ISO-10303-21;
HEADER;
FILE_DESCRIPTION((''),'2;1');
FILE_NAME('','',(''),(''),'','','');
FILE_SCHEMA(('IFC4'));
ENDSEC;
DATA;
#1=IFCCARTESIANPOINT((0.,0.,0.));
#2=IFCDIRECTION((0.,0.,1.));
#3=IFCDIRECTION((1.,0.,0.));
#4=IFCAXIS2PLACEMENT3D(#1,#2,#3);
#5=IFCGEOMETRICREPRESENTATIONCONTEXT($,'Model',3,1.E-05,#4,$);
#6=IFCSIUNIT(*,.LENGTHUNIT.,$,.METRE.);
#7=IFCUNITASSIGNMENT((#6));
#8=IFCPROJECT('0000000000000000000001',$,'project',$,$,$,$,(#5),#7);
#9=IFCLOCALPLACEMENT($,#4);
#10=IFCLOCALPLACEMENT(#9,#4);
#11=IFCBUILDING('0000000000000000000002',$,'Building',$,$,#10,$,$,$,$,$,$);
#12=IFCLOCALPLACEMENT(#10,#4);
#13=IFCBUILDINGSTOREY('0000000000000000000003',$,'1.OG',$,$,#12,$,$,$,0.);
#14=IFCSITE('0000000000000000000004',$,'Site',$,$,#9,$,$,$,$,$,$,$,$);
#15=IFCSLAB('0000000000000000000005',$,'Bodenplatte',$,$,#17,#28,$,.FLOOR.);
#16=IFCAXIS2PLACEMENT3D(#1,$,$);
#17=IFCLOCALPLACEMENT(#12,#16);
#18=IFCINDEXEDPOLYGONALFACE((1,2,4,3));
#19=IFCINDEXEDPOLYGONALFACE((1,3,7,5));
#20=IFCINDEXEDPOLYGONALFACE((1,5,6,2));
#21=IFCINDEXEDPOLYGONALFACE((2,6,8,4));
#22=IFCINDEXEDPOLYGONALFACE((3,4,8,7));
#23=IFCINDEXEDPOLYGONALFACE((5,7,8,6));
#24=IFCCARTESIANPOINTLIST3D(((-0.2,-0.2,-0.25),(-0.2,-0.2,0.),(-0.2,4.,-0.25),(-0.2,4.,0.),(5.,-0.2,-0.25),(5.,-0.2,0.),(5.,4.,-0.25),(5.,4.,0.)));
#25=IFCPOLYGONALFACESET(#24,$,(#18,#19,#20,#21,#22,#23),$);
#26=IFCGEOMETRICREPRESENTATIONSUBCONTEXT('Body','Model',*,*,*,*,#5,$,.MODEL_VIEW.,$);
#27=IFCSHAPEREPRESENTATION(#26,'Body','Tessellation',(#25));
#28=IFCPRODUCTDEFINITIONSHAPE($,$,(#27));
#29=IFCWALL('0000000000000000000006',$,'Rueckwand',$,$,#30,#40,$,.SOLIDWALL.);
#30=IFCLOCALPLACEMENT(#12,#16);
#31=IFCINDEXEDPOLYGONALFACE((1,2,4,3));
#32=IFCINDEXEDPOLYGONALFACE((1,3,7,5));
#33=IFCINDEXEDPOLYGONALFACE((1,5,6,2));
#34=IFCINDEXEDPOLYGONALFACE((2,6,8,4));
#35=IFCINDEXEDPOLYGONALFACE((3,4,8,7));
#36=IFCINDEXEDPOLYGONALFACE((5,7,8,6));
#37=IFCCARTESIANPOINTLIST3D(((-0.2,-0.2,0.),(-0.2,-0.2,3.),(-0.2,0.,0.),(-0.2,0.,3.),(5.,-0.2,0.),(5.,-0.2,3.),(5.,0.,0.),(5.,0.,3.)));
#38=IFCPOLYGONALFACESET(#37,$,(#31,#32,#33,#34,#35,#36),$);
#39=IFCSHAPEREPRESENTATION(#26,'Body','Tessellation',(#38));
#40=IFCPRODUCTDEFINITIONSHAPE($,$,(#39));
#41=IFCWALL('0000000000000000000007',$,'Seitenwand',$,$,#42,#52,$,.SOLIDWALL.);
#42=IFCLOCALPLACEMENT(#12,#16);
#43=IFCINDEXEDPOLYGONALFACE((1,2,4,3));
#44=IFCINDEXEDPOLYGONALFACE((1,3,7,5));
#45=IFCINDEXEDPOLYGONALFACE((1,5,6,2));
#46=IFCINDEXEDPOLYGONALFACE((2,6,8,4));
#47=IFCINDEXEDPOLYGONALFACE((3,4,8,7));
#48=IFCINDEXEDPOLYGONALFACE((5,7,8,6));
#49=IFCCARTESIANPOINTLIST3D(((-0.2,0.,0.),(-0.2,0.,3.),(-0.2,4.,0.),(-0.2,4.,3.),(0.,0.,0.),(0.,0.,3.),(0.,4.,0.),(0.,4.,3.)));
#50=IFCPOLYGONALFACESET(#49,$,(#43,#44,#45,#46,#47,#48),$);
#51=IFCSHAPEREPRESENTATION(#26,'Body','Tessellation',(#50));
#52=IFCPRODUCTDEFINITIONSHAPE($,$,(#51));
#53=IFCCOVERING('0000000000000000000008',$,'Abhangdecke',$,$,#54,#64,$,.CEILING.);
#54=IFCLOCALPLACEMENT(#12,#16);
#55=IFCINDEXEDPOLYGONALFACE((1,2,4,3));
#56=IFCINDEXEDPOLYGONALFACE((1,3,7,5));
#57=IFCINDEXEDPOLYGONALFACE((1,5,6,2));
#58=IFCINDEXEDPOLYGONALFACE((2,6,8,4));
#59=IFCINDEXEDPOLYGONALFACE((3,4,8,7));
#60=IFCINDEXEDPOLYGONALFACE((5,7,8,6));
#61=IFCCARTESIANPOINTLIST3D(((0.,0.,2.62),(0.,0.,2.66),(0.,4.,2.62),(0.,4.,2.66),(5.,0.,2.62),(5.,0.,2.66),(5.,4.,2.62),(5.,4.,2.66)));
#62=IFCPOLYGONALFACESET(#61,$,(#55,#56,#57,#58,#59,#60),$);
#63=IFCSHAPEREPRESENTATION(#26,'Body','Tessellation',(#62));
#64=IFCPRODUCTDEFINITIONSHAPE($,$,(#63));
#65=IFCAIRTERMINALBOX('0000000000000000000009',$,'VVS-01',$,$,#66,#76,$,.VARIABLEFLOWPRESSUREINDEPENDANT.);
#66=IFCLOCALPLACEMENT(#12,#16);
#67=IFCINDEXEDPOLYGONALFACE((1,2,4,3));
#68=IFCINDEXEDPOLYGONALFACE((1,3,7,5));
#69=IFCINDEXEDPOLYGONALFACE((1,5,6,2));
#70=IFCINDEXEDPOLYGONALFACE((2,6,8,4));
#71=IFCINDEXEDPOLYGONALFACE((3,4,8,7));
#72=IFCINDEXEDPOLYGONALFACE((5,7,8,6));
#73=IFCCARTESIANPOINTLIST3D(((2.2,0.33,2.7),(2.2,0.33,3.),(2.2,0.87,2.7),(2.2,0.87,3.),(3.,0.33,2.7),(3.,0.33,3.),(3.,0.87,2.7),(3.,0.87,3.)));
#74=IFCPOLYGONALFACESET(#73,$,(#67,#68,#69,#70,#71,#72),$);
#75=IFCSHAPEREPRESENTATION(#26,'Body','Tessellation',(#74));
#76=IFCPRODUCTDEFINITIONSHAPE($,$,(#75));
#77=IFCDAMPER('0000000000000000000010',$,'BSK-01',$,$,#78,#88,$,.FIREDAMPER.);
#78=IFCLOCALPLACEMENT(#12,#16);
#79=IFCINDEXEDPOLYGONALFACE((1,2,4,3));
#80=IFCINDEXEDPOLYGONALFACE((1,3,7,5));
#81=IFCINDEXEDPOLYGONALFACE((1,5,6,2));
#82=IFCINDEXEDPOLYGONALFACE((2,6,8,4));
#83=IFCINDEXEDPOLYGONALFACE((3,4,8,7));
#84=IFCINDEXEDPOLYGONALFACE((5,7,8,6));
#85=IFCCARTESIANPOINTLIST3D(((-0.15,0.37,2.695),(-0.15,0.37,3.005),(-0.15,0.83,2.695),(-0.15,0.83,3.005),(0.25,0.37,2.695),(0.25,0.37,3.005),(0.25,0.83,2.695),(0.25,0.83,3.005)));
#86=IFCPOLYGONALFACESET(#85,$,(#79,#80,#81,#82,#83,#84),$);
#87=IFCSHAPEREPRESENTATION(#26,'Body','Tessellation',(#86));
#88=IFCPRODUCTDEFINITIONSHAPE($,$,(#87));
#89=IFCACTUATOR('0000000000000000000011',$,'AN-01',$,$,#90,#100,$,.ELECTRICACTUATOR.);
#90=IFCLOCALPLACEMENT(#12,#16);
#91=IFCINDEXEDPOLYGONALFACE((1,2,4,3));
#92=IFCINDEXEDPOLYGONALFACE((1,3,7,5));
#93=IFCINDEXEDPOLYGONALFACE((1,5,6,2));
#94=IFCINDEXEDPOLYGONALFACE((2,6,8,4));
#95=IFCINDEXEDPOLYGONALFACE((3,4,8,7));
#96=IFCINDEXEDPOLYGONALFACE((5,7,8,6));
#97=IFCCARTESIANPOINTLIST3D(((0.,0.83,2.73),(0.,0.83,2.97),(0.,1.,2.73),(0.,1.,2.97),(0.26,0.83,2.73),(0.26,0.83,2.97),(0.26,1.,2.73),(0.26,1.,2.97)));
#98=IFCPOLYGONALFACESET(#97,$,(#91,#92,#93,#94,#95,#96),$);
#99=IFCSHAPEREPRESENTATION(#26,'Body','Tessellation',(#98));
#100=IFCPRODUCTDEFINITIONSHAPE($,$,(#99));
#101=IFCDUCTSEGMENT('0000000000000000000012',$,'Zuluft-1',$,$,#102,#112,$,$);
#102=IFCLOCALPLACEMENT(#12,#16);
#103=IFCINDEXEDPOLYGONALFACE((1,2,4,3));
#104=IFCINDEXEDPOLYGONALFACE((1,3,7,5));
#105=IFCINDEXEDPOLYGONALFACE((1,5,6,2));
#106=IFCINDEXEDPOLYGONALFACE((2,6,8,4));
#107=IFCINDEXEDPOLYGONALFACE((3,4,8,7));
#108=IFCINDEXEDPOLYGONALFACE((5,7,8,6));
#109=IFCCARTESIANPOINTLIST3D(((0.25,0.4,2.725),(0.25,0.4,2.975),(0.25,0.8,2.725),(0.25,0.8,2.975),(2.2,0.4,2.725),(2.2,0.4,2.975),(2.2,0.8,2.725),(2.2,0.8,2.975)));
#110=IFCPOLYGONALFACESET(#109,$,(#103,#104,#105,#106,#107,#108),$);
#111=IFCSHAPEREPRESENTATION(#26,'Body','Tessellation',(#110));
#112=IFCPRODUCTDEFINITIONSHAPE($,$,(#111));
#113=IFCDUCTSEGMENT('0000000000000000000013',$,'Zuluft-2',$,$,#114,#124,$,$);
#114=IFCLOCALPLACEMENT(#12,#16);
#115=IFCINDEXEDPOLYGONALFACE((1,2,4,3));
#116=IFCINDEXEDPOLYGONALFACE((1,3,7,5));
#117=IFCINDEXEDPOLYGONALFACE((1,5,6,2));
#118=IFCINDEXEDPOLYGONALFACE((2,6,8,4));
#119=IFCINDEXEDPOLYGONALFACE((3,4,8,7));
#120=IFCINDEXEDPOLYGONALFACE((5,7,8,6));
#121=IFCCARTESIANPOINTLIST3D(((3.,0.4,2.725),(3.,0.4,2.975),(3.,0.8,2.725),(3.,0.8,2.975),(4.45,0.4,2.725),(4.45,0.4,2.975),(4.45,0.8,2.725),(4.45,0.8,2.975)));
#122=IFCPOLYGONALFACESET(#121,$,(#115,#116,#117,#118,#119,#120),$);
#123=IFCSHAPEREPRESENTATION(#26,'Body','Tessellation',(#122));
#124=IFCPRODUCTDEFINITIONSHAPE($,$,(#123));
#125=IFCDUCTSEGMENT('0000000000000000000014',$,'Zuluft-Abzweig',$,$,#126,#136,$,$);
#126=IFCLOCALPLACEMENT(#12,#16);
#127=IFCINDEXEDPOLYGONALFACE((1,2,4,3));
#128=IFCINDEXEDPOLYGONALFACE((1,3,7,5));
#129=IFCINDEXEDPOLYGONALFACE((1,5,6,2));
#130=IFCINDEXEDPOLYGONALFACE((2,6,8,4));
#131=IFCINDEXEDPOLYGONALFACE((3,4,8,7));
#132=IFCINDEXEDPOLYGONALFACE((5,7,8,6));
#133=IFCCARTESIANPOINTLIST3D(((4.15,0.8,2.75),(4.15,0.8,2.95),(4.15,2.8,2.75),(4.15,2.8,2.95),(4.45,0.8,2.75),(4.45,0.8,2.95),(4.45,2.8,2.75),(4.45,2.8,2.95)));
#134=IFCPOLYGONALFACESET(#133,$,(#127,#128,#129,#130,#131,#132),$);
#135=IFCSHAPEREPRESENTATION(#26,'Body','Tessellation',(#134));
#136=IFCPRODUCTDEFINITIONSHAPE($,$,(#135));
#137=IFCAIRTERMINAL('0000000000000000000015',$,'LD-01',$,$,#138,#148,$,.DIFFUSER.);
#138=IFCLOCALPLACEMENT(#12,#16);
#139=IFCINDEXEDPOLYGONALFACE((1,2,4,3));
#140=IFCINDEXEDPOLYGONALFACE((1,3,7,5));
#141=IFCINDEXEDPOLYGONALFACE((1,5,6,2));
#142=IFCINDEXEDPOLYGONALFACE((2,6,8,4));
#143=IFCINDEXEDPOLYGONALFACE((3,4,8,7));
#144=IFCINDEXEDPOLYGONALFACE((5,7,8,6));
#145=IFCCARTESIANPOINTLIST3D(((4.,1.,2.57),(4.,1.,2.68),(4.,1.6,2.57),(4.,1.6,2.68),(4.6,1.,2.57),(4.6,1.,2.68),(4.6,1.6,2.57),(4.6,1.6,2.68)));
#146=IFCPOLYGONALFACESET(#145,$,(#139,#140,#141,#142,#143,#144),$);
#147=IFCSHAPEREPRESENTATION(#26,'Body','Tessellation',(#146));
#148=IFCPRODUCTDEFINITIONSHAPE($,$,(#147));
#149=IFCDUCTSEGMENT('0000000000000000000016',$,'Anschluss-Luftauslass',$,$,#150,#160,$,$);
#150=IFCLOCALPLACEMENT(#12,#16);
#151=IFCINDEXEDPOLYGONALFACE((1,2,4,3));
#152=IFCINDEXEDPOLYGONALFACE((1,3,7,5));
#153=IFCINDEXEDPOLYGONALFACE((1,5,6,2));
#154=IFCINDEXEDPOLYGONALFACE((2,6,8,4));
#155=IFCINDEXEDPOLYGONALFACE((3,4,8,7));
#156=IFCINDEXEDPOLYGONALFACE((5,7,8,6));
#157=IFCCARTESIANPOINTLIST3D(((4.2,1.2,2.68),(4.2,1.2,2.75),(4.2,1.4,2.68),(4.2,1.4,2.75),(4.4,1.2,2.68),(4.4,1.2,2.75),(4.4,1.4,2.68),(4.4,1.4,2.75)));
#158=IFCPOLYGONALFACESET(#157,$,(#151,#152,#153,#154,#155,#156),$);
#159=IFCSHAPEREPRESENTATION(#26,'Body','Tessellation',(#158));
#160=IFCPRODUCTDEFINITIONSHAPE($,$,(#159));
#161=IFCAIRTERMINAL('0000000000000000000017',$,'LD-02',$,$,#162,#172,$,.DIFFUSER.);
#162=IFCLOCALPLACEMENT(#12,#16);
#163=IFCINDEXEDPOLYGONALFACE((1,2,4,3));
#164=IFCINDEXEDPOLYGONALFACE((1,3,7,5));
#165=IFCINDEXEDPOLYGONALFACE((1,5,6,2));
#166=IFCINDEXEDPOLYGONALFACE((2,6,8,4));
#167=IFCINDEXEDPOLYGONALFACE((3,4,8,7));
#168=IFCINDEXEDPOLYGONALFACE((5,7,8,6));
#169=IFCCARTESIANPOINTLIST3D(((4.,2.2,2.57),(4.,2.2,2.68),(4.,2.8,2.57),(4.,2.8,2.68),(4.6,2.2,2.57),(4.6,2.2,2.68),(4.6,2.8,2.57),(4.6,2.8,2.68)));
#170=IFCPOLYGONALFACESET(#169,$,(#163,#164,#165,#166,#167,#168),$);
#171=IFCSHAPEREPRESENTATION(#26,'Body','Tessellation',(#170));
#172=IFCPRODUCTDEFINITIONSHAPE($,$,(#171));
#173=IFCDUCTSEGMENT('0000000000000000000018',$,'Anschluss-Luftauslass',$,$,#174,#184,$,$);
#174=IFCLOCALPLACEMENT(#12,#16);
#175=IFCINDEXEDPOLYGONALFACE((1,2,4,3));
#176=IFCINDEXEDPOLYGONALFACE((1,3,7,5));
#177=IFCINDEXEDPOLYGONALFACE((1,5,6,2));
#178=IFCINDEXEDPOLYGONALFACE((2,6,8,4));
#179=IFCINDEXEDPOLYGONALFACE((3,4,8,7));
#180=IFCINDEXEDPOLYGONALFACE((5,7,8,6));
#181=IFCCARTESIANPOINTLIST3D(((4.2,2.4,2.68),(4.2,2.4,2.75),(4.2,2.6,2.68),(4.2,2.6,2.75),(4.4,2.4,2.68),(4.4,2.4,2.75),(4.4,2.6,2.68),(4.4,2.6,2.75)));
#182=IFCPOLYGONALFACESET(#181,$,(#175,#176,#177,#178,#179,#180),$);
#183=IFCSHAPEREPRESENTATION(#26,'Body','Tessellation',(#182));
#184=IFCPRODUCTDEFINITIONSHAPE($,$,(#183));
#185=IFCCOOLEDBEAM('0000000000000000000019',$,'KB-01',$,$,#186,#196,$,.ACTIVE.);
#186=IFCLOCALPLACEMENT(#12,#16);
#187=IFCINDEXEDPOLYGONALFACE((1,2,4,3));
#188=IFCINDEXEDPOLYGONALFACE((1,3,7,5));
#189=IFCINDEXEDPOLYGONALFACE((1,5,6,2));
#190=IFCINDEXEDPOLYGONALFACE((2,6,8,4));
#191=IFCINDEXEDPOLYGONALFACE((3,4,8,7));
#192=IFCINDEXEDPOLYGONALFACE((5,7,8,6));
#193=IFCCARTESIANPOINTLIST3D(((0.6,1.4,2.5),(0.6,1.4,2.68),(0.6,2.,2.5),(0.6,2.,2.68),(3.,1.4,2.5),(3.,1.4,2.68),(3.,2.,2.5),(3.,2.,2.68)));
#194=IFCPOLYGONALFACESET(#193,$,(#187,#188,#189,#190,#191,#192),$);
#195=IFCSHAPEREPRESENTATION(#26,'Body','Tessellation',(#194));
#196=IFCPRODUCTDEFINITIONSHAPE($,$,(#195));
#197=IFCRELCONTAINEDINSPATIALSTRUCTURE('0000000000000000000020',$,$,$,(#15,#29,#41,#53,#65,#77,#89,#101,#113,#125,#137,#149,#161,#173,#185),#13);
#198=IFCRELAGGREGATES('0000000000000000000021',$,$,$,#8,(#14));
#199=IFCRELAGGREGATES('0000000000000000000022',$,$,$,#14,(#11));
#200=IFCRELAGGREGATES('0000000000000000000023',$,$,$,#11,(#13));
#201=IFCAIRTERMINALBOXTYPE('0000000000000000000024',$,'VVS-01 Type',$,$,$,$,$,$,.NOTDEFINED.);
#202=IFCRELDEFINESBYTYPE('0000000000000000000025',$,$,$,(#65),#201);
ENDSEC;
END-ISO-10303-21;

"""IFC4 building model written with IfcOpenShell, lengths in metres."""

from ifc_helpers import new_model, si_unit, frame, origin_with_axes, place, context, subcontext, project, spatial, polyline, outline, extrude, type_object, element, save


model = new_model("IFC4")

# Units and contexts
model_context = context("Model", 3, precision=1e-05, world=origin_with_axes())
body_context = subcontext(model_context, "Body", "Model", "MODEL_VIEW")
ifc_project = project(units=[si_unit("LENGTHUNIT", "METRE")], contexts=[model_context])

# Site, building, storey
site_placement = place(None, origin_with_axes())
site = spatial("IfcSite", under=ifc_project, at=site_placement, Name="Site")
building_placement = place(site_placement, origin_with_axes())
building = spatial("IfcBuilding", under=site, at=building_placement, Name="Building")
storey_placement = place(building_placement, origin_with_axes())
storey = spatial("IfcBuildingStorey", under=building, at=storey_placement, Name="1.OG", Elevation=0.0)

# Slab
slab_placement = place(storey_placement, frame((0.0, 0.0, -0.25), z_axis=(0.0, 0.0, 1.0), x_axis=(1.0, 0.0, 0.0)))
element("IfcSlab", 1, at=slab_placement, inside=storey, Name="Bodenplatte", PredefinedType="FLOOR", context=body_context, shape_type="SweptSolid", body=[
    extrude(outline(polyline([(-0.2, -0.2, 0.0), (5.0, -0.2, 0.0), (5.0, 4.0, 0.0), (-0.2, 4.0, 0.0), (-0.2, -0.2, 0.0)])), origin_with_axes(), (0.0, 0.0, 1.0), 0.25),
])

# Walls
wall_1_placement = place(storey_placement, frame((-0.2, -0.2, 0.0), z_axis=(0.0, 0.0, 1.0), x_axis=(1.0, 0.0, 0.0)))
element("IfcWall", 2, at=wall_1_placement, inside=storey, Name="Rueckwand", PredefinedType="SOLIDWALL", context=body_context, shape_type="SweptSolid", body=[
    extrude(outline(polyline([(0.0, 0.0, 0.0), (5.2, 0.0, 0.0), (5.2, 0.2, 0.0), (0.0, 0.2, 0.0), (0.0, 0.0, 0.0)])), origin_with_axes(), (0.0, 0.0, 1.0), 3.0),
])
wall_2_placement = place(storey_placement, frame((0.0, 0.0, 0.0), z_axis=(0.0, 0.0, 1.0), x_axis=(0.0, 1.0, 0.0)))
element("IfcWall", 3, at=wall_2_placement, inside=storey, Name="Seitenwand", PredefinedType="SOLIDWALL", context=body_context, shape_type="SweptSolid", body=[
    extrude(outline(polyline([(0.0, 0.0, 0.0), (4.0, 0.0, 0.0), (4.0, 0.2, 0.0), (0.0, 0.2, 0.0), (0.0, 0.0, 0.0)])), origin_with_axes(), (0.0, 0.0, 1.0), 3.0),
])

# Covering
covering_placement = place(storey_placement, frame((0.0, 0.0, 2.62), z_axis=(0.0, 0.0, 1.0), x_axis=(1.0, 0.0, 0.0)))
element("IfcCovering", 4, at=covering_placement, inside=storey, Name="Abhangdecke", PredefinedType="CEILING", context=body_context, shape_type="SweptSolid", body=[
    extrude(outline(polyline([(0.0, 0.0, 0.0), (5.0, 0.0, 0.0), (5.0, 4.0, 0.0), (0.0, 4.0, 0.0), (0.0, 0.0, 0.0)])), origin_with_axes(), (0.0, 0.0, 1.0), 0.04),
])

# Air terminal box
air_terminal_box_type = type_object("IfcAirTerminalBoxType", Name="VVS-01 Type", PredefinedType="NOTDEFINED")
air_terminal_box_placement = place(storey_placement, origin_with_axes())
element("IfcAirTerminalBox", 5, at=air_terminal_box_placement, inside=storey, type_object=air_terminal_box_type, Name="VVS-01", PredefinedType="VARIABLEFLOWPRESSUREINDEPENDANT", context=body_context, shape_type="SweptSolid", body=[
    extrude(outline(polyline([(2.2, 0.33, 0.0), (3.0, 0.33, 0.0), (3.0, 0.87, 0.0), (2.2, 0.87, 0.0), (2.2, 0.33, 0.0)])), frame((0.0, 0.0, 2.7), z_axis=(0.0, 0.0, 1.0), x_axis=(1.0, 0.0, 0.0)), (0.0, 0.0, 1.0), 0.3),
])

# Damper
damper_placement = place(storey_placement, origin_with_axes())
element("IfcDamper", 6, at=damper_placement, inside=storey, Name="BSK-01", PredefinedType="FIREDAMPER", context=body_context, shape_type="SweptSolid", body=[
    extrude(outline(polyline([(-0.15, 0.37, 0.0), (0.25, 0.37, 0.0), (0.25, 0.83, 0.0), (-0.15, 0.83, 0.0), (-0.15, 0.37, 0.0)])), frame((0.0, 0.0, 2.695), z_axis=(0.0, 0.0, 1.0), x_axis=(1.0, 0.0, 0.0)), (0.0, 0.0, 1.0), 0.31),
])

# Actuator
actuator_placement = place(storey_placement, origin_with_axes())
element("IfcActuator", 7, at=actuator_placement, inside=storey, Name="AN-01", PredefinedType="ELECTRICACTUATOR", context=body_context, shape_type="SweptSolid", body=[
    extrude(outline(polyline([(0.0, 0.83, 0.0), (0.26, 0.83, 0.0), (0.26, 1.0, 0.0), (0.0, 1.0, 0.0), (0.0, 0.83, 0.0)])), frame((0.0, 0.0, 2.73), z_axis=(0.0, 0.0, 1.0), x_axis=(1.0, 0.0, 0.0)), (0.0, 0.0, 1.0), 0.24),
])

# Duct segments
duct_segment_1_placement = place(storey_placement, origin_with_axes())
element("IfcDuctSegment", 8, at=duct_segment_1_placement, inside=storey, Name="Zuluft-1", context=body_context, shape_type="SweptSolid", body=[
    extrude(outline(polyline([(-0.2, -0.125, 0.0), (0.2, -0.125, 0.0), (0.2, 0.125, 0.0), (-0.2, 0.125, 0.0), (-0.2, -0.125, 0.0)])), frame((0.25, 0.6, 2.85), z_axis=(1.0, 0.0, 0.0), x_axis=(0.0, 1.0, 0.0)), (0.0, 0.0, 1.0), 1.95),
])
duct_segment_2_placement = place(storey_placement, origin_with_axes())
element("IfcDuctSegment", 9, at=duct_segment_2_placement, inside=storey, Name="Zuluft-2", context=body_context, shape_type="SweptSolid", body=[
    extrude(outline(polyline([(-0.2, -0.125, 0.0), (0.2, -0.125, 0.0), (0.2, 0.125, 0.0), (-0.2, 0.125, 0.0), (-0.2, -0.125, 0.0)])), frame((3.0, 0.6, 2.85), z_axis=(1.0, 0.0, 0.0), x_axis=(0.0, 1.0, 0.0)), (0.0, 0.0, 1.0), 1.45),
])
duct_segment_3_placement = place(storey_placement, origin_with_axes())
element("IfcDuctSegment", 10, at=duct_segment_3_placement, inside=storey, Name="Zuluft-Abzweig", context=body_context, shape_type="SweptSolid", body=[
    extrude(outline(polyline([(-0.15, -0.1, 0.0), (0.15, -0.1, 0.0), (0.15, 0.1, 0.0), (-0.15, 0.1, 0.0), (-0.15, -0.1, 0.0)])), frame((4.3, 0.8, 2.85), z_axis=(0.0, 1.0, 0.0), x_axis=(-1.0, 0.0, 0.0)), (0.0, 0.0, 1.0), 2.0),
])

# Air terminal
air_terminal_1_placement = place(storey_placement, origin_with_axes())
element("IfcAirTerminal", 11, at=air_terminal_1_placement, inside=storey, Name="LD-01", PredefinedType="DIFFUSER", context=body_context, shape_type="SweptSolid", body=[
    extrude(outline(polyline([(4.0, 1.0, 0.0), (4.6, 1.0, 0.0), (4.6, 1.6, 0.0), (4.0, 1.6, 0.0), (4.0, 1.0, 0.0)])), frame((0.0, 0.0, 2.57), z_axis=(0.0, 0.0, 1.0), x_axis=(1.0, 0.0, 0.0)), (0.0, 0.0, 1.0), 0.11),
])

# Duct segment
duct_segment_4_placement = place(storey_placement, origin_with_axes())
element("IfcDuctSegment", 12, at=duct_segment_4_placement, inside=storey, Name="Anschluss-Luftauslass", context=body_context, shape_type="SweptSolid", body=[
    extrude(outline(polyline([(-0.1, -0.1, 0.0), (0.1, -0.1, 0.0), (0.1, 0.1, 0.0), (-0.1, 0.1, 0.0), (-0.1, -0.1, 0.0)])), frame((4.3, 1.3, 2.68), z_axis=(0.0, 0.0, 1.0), x_axis=(1.0, 0.0, 0.0)), (0.0, 0.0, 1.0), 0.07),
])

# Air terminal
air_terminal_2_placement = place(storey_placement, origin_with_axes())
element("IfcAirTerminal", 13, at=air_terminal_2_placement, inside=storey, Name="LD-02", PredefinedType="DIFFUSER", context=body_context, shape_type="SweptSolid", body=[
    extrude(outline(polyline([(4.0, 2.2, 0.0), (4.6, 2.2, 0.0), (4.6, 2.8, 0.0), (4.0, 2.8, 0.0), (4.0, 2.2, 0.0)])), frame((0.0, 0.0, 2.57), z_axis=(0.0, 0.0, 1.0), x_axis=(1.0, 0.0, 0.0)), (0.0, 0.0, 1.0), 0.11),
])

# Duct segment
duct_segment_5_placement = place(storey_placement, origin_with_axes())
element("IfcDuctSegment", 14, at=duct_segment_5_placement, inside=storey, Name="Anschluss-Luftauslass", context=body_context, shape_type="SweptSolid", body=[
    extrude(outline(polyline([(-0.1, -0.1, 0.0), (0.1, -0.1, 0.0), (0.1, 0.1, 0.0), (-0.1, 0.1, 0.0), (-0.1, -0.1, 0.0)])), frame((4.3, 2.5, 2.68), z_axis=(0.0, 0.0, 1.0), x_axis=(1.0, 0.0, 0.0)), (0.0, 0.0, 1.0), 0.07),
])

# Cooled beam
cooled_beam_placement = place(storey_placement, origin_with_axes())
element("IfcCooledBeam", 15, at=cooled_beam_placement, inside=storey, Name="KB-01", PredefinedType="ACTIVE", context=body_context, shape_type="SweptSolid", body=[
    extrude(outline(polyline([(0.6, 1.4, 0.0), (3.0, 1.4, 0.0), (3.0, 2.0, 0.0), (0.6, 2.0, 0.0), (0.6, 1.4, 0.0)])), frame((0.0, 0.0, 2.5), z_axis=(0.0, 0.0, 1.0), x_axis=(1.0, 0.0, 0.0)), (0.0, 0.0, 1.0), 0.18),
])

save(model, "model.ifc")
